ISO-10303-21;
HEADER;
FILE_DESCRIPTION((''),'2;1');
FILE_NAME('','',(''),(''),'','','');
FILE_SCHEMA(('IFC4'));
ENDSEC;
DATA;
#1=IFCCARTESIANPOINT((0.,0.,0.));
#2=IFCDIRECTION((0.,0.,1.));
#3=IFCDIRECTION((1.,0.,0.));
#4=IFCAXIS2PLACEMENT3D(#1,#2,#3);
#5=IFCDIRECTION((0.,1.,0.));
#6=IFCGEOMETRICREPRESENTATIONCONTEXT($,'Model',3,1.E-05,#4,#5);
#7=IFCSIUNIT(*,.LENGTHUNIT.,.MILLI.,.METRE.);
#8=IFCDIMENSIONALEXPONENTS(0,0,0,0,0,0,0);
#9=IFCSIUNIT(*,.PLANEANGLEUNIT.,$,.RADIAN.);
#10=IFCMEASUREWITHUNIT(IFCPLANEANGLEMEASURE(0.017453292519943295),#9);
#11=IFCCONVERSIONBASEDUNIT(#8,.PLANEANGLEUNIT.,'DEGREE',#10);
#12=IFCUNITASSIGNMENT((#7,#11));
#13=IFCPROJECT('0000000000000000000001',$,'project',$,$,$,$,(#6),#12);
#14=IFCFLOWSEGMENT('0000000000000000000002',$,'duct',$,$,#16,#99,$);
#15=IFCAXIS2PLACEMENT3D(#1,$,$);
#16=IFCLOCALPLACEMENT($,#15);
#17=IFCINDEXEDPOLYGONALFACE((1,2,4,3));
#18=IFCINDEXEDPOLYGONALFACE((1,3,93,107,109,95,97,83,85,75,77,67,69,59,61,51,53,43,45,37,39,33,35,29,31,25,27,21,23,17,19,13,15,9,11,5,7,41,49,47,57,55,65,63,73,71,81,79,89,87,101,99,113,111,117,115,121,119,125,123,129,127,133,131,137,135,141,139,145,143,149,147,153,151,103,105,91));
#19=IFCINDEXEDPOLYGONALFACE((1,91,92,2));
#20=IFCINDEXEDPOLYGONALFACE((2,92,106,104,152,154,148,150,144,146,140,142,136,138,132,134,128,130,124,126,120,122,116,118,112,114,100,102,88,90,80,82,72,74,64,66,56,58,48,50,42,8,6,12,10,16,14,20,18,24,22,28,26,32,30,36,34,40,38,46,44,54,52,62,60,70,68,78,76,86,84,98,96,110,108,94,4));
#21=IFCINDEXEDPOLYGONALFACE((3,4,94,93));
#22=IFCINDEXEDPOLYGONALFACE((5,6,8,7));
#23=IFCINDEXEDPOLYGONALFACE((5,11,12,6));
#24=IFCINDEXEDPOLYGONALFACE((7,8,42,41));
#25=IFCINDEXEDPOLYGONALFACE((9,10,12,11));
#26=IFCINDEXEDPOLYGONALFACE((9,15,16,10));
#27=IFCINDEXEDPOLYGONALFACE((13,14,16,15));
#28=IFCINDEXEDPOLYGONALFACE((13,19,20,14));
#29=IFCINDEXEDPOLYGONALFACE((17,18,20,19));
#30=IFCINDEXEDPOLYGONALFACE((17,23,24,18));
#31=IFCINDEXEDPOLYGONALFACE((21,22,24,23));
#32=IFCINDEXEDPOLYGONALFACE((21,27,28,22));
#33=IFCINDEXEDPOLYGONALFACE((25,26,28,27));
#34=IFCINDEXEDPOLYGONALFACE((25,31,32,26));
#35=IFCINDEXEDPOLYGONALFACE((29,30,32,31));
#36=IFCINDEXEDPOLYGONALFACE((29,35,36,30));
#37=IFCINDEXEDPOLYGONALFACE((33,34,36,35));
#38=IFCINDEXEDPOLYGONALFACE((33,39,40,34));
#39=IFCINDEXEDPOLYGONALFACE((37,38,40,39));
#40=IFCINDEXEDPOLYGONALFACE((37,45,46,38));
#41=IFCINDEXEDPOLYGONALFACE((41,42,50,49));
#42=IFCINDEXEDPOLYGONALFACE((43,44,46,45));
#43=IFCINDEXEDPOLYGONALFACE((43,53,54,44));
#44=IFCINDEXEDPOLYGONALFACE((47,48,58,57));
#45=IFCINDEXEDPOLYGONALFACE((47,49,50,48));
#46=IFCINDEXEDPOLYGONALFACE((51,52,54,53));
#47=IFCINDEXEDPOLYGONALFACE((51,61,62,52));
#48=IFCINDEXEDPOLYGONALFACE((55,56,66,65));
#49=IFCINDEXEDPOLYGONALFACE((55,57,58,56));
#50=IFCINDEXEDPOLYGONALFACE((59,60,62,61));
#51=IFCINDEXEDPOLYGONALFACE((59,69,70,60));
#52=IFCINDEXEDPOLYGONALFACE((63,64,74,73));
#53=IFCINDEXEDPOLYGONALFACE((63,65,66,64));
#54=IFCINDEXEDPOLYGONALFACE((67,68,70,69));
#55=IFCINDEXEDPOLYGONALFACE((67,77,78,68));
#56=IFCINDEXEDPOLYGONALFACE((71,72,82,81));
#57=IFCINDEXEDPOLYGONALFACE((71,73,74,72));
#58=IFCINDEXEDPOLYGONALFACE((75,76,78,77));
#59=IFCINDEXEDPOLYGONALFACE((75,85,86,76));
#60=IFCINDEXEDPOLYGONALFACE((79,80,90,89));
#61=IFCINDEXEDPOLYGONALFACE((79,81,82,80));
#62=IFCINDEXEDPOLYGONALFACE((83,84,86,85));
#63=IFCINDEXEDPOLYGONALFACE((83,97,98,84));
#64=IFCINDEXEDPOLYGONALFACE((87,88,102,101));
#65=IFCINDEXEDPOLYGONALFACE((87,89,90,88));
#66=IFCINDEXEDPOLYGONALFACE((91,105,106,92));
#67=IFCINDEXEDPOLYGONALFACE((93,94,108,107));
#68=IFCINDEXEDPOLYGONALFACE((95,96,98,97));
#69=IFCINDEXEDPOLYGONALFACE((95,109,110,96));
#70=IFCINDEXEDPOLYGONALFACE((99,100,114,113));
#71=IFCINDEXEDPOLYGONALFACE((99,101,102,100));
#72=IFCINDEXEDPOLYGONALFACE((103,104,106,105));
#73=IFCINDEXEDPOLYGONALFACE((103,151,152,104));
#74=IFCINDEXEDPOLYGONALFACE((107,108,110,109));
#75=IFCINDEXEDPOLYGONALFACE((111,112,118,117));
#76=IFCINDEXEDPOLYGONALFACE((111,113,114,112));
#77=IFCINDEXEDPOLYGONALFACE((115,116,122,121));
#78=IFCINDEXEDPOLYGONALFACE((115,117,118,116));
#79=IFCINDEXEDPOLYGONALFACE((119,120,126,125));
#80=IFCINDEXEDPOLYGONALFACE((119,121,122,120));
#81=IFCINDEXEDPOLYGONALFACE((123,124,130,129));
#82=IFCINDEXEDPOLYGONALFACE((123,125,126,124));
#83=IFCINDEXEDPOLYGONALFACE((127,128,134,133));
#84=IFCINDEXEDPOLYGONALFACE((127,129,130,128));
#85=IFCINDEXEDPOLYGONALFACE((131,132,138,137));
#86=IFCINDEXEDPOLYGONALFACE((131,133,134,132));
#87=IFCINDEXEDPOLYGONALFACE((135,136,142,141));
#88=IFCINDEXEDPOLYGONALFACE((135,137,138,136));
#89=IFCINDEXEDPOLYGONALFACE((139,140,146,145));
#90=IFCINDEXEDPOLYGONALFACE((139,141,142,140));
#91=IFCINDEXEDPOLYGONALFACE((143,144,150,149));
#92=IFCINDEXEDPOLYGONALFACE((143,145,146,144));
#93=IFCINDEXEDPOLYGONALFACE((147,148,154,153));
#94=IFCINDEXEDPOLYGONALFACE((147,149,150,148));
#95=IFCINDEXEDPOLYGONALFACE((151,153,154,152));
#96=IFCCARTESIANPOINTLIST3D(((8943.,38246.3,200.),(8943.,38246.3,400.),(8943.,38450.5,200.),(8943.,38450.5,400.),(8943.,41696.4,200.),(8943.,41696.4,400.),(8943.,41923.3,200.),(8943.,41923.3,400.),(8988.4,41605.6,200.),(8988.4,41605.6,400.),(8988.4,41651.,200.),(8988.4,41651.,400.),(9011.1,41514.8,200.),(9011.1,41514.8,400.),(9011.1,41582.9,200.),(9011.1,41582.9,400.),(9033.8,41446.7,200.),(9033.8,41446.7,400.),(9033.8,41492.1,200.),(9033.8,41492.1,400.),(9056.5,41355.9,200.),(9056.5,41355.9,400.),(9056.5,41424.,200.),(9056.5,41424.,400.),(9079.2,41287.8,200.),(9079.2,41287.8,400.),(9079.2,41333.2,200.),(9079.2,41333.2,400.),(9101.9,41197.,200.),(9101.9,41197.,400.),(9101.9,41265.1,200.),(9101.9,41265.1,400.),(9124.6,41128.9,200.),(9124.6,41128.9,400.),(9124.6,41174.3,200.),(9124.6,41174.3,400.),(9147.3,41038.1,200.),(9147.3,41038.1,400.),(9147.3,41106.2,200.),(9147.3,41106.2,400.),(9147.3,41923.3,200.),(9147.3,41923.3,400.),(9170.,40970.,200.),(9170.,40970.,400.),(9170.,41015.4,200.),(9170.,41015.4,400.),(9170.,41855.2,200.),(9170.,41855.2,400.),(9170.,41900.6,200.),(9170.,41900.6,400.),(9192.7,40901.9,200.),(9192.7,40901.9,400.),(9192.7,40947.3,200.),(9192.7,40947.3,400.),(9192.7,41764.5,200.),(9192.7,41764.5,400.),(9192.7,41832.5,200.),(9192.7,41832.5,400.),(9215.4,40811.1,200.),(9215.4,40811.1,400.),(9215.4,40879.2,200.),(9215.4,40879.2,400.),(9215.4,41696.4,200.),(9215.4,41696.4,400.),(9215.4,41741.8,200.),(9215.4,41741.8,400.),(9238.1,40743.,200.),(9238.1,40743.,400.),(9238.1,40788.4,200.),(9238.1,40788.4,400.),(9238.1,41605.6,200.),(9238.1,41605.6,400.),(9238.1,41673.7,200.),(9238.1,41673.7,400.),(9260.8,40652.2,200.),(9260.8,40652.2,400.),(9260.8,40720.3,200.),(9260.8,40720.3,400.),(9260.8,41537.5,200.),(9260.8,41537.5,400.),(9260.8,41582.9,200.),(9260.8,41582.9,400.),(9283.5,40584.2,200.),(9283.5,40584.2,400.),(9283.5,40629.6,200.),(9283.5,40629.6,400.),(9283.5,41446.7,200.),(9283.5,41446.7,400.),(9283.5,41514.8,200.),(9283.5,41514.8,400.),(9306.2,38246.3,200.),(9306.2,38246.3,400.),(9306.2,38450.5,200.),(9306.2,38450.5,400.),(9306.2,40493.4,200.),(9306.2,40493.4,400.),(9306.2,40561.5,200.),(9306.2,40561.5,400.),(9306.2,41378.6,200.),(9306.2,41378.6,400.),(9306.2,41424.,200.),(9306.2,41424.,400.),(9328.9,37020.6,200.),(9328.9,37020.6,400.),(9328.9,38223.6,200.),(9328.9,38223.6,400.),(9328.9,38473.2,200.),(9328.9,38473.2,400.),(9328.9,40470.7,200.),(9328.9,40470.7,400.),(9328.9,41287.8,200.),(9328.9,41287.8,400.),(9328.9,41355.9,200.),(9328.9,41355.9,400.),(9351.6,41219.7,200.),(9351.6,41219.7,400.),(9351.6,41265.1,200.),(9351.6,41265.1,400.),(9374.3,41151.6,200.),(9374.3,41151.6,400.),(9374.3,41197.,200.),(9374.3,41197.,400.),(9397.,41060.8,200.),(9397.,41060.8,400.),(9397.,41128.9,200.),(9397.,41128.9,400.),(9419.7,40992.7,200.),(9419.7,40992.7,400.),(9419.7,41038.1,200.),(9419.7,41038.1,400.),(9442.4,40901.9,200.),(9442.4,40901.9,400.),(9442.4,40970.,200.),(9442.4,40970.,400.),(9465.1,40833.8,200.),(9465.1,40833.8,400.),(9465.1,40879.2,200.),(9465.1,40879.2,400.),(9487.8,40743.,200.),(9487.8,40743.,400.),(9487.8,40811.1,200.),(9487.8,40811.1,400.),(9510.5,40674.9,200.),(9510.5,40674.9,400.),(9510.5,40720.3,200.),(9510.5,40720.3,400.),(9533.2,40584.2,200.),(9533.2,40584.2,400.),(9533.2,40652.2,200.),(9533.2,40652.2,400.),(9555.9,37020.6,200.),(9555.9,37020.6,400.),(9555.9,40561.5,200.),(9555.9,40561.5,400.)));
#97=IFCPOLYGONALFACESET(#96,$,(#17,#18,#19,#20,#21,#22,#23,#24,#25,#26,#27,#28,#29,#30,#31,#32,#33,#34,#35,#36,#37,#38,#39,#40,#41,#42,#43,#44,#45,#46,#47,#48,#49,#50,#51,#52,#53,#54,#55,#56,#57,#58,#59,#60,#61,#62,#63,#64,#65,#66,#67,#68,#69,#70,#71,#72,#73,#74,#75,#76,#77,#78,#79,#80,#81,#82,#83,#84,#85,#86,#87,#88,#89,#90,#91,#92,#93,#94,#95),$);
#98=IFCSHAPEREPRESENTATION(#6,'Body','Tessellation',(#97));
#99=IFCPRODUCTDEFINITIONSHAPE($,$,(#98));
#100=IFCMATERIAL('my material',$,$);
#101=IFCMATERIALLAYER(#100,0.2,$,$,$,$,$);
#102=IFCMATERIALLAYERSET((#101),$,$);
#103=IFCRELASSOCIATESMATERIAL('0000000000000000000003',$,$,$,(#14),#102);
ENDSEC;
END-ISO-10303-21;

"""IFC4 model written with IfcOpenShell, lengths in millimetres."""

from ifc_helpers import new_model, entity, si_unit, converted_unit, direction, frame, origin_with_axes, place, context, project, polyline, outline, extrude, material, layer, layer_set, layer_usage, element, save


model = new_model("IFC4")

# Units and contexts
model_context = context("Model", 3, precision=1e-05, world=origin_with_axes(), true_north=direction((0.0, 1.0, 0.0)))
ifc_project = project(units=[si_unit("LENGTHUNIT", "METRE", prefix="MILLI"), converted_unit("PLANEANGLEUNIT", "DEGREE", entity("IfcPlaneAngleMeasure", 0.017453292519943295), si_unit("PLANEANGLEUNIT", "RADIAN"), dimensions=[0, 0, 0, 0, 0, 0, 0])], contexts=[model_context])

# Flow segment
ifc_material_1 = material(Name="my material")
ifc_layer_1 = layer(ifc_material_1, 0.2)
ifc_layer_set_1 = layer_set([ifc_layer_1])
ifc_layer_usage_1 = layer_usage(ifc_layer_set_1, "AXIS2", "POSITIVE", -0.1)
flow_segment_1_placement = place(None, origin_with_axes())
element("IfcFlowSegment", 1, at=flow_segment_1_placement, material=ifc_layer_usage_1, Name="duct", context=model_context, shape_type="SweptSolid", body=[
    extrude(outline(polyline([(8943.0, 38246.3), (9306.2, 38246.3), (9328.9, 38223.6), (9328.9, 37020.6), (9555.9, 37020.6), (9555.9, 40561.5), (9533.2, 40584.2), (9533.2, 40652.2), (9510.5, 40674.9), (9510.5, 40720.3), (9487.8, 40743.0), (9487.8, 40811.1), (9465.1, 40833.8), (9465.1, 40879.2), (9442.4, 40901.9), (9442.4, 40970.0), (9419.7, 40992.7), (9419.7, 41038.1), (9397.0, 41060.8), (9397.0, 41128.9), (9374.3, 41151.6), (9374.3, 41197.0), (9351.6, 41219.7), (9351.6, 41265.1), (9328.9, 41287.8), (9328.9, 41355.9), (9306.2, 41378.6), (9306.2, 41424.0), (9283.5, 41446.7), (9283.5, 41514.8), (9260.8, 41537.5), (9260.8, 41582.9), (9238.1, 41605.6), (9238.1, 41673.7), (9215.4, 41696.4), (9215.4, 41741.8), (9192.7, 41764.5), (9192.7, 41832.5), (9170.0, 41855.2), (9170.0, 41900.6), (9147.3, 41923.3), (8943.0, 41923.3), (8943.0, 41696.4), (8988.4, 41651.0), (8988.4, 41605.6), (9011.1, 41582.9), (9011.1, 41514.8), (9033.8, 41492.1), (9033.8, 41446.7), (9056.5, 41424.0), (9056.5, 41355.9), (9079.2, 41333.2), (9079.2, 41287.8), (9101.9, 41265.1), (9101.9, 41197.0), (9124.6, 41174.3), (9124.6, 41128.9), (9147.3, 41106.2), (9147.3, 41038.1), (9170.0, 41015.4), (9170.0, 40970.0), (9192.7, 40947.3), (9192.7, 40901.9), (9215.4, 40879.2), (9215.4, 40811.1), (9238.1, 40788.4), (9238.1, 40743.0), (9260.8, 40720.3), (9260.8, 40652.2), (9283.5, 40629.6), (9283.5, 40584.2), (9306.2, 40561.5), (9306.2, 40493.4), (9328.9, 40470.7), (9328.9, 38473.2), (9306.2, 38450.5), (8943.0, 38450.5), (8943.0, 38246.3)])), frame((0.0, 0.0, 200.0), z_axis=(0.0, 0.0, 1.0), x_axis=(1.0, 0.0, 0.0)), (0.0, 0.0, 1.0), 200.0),
])

save(model, "model.ifc")
